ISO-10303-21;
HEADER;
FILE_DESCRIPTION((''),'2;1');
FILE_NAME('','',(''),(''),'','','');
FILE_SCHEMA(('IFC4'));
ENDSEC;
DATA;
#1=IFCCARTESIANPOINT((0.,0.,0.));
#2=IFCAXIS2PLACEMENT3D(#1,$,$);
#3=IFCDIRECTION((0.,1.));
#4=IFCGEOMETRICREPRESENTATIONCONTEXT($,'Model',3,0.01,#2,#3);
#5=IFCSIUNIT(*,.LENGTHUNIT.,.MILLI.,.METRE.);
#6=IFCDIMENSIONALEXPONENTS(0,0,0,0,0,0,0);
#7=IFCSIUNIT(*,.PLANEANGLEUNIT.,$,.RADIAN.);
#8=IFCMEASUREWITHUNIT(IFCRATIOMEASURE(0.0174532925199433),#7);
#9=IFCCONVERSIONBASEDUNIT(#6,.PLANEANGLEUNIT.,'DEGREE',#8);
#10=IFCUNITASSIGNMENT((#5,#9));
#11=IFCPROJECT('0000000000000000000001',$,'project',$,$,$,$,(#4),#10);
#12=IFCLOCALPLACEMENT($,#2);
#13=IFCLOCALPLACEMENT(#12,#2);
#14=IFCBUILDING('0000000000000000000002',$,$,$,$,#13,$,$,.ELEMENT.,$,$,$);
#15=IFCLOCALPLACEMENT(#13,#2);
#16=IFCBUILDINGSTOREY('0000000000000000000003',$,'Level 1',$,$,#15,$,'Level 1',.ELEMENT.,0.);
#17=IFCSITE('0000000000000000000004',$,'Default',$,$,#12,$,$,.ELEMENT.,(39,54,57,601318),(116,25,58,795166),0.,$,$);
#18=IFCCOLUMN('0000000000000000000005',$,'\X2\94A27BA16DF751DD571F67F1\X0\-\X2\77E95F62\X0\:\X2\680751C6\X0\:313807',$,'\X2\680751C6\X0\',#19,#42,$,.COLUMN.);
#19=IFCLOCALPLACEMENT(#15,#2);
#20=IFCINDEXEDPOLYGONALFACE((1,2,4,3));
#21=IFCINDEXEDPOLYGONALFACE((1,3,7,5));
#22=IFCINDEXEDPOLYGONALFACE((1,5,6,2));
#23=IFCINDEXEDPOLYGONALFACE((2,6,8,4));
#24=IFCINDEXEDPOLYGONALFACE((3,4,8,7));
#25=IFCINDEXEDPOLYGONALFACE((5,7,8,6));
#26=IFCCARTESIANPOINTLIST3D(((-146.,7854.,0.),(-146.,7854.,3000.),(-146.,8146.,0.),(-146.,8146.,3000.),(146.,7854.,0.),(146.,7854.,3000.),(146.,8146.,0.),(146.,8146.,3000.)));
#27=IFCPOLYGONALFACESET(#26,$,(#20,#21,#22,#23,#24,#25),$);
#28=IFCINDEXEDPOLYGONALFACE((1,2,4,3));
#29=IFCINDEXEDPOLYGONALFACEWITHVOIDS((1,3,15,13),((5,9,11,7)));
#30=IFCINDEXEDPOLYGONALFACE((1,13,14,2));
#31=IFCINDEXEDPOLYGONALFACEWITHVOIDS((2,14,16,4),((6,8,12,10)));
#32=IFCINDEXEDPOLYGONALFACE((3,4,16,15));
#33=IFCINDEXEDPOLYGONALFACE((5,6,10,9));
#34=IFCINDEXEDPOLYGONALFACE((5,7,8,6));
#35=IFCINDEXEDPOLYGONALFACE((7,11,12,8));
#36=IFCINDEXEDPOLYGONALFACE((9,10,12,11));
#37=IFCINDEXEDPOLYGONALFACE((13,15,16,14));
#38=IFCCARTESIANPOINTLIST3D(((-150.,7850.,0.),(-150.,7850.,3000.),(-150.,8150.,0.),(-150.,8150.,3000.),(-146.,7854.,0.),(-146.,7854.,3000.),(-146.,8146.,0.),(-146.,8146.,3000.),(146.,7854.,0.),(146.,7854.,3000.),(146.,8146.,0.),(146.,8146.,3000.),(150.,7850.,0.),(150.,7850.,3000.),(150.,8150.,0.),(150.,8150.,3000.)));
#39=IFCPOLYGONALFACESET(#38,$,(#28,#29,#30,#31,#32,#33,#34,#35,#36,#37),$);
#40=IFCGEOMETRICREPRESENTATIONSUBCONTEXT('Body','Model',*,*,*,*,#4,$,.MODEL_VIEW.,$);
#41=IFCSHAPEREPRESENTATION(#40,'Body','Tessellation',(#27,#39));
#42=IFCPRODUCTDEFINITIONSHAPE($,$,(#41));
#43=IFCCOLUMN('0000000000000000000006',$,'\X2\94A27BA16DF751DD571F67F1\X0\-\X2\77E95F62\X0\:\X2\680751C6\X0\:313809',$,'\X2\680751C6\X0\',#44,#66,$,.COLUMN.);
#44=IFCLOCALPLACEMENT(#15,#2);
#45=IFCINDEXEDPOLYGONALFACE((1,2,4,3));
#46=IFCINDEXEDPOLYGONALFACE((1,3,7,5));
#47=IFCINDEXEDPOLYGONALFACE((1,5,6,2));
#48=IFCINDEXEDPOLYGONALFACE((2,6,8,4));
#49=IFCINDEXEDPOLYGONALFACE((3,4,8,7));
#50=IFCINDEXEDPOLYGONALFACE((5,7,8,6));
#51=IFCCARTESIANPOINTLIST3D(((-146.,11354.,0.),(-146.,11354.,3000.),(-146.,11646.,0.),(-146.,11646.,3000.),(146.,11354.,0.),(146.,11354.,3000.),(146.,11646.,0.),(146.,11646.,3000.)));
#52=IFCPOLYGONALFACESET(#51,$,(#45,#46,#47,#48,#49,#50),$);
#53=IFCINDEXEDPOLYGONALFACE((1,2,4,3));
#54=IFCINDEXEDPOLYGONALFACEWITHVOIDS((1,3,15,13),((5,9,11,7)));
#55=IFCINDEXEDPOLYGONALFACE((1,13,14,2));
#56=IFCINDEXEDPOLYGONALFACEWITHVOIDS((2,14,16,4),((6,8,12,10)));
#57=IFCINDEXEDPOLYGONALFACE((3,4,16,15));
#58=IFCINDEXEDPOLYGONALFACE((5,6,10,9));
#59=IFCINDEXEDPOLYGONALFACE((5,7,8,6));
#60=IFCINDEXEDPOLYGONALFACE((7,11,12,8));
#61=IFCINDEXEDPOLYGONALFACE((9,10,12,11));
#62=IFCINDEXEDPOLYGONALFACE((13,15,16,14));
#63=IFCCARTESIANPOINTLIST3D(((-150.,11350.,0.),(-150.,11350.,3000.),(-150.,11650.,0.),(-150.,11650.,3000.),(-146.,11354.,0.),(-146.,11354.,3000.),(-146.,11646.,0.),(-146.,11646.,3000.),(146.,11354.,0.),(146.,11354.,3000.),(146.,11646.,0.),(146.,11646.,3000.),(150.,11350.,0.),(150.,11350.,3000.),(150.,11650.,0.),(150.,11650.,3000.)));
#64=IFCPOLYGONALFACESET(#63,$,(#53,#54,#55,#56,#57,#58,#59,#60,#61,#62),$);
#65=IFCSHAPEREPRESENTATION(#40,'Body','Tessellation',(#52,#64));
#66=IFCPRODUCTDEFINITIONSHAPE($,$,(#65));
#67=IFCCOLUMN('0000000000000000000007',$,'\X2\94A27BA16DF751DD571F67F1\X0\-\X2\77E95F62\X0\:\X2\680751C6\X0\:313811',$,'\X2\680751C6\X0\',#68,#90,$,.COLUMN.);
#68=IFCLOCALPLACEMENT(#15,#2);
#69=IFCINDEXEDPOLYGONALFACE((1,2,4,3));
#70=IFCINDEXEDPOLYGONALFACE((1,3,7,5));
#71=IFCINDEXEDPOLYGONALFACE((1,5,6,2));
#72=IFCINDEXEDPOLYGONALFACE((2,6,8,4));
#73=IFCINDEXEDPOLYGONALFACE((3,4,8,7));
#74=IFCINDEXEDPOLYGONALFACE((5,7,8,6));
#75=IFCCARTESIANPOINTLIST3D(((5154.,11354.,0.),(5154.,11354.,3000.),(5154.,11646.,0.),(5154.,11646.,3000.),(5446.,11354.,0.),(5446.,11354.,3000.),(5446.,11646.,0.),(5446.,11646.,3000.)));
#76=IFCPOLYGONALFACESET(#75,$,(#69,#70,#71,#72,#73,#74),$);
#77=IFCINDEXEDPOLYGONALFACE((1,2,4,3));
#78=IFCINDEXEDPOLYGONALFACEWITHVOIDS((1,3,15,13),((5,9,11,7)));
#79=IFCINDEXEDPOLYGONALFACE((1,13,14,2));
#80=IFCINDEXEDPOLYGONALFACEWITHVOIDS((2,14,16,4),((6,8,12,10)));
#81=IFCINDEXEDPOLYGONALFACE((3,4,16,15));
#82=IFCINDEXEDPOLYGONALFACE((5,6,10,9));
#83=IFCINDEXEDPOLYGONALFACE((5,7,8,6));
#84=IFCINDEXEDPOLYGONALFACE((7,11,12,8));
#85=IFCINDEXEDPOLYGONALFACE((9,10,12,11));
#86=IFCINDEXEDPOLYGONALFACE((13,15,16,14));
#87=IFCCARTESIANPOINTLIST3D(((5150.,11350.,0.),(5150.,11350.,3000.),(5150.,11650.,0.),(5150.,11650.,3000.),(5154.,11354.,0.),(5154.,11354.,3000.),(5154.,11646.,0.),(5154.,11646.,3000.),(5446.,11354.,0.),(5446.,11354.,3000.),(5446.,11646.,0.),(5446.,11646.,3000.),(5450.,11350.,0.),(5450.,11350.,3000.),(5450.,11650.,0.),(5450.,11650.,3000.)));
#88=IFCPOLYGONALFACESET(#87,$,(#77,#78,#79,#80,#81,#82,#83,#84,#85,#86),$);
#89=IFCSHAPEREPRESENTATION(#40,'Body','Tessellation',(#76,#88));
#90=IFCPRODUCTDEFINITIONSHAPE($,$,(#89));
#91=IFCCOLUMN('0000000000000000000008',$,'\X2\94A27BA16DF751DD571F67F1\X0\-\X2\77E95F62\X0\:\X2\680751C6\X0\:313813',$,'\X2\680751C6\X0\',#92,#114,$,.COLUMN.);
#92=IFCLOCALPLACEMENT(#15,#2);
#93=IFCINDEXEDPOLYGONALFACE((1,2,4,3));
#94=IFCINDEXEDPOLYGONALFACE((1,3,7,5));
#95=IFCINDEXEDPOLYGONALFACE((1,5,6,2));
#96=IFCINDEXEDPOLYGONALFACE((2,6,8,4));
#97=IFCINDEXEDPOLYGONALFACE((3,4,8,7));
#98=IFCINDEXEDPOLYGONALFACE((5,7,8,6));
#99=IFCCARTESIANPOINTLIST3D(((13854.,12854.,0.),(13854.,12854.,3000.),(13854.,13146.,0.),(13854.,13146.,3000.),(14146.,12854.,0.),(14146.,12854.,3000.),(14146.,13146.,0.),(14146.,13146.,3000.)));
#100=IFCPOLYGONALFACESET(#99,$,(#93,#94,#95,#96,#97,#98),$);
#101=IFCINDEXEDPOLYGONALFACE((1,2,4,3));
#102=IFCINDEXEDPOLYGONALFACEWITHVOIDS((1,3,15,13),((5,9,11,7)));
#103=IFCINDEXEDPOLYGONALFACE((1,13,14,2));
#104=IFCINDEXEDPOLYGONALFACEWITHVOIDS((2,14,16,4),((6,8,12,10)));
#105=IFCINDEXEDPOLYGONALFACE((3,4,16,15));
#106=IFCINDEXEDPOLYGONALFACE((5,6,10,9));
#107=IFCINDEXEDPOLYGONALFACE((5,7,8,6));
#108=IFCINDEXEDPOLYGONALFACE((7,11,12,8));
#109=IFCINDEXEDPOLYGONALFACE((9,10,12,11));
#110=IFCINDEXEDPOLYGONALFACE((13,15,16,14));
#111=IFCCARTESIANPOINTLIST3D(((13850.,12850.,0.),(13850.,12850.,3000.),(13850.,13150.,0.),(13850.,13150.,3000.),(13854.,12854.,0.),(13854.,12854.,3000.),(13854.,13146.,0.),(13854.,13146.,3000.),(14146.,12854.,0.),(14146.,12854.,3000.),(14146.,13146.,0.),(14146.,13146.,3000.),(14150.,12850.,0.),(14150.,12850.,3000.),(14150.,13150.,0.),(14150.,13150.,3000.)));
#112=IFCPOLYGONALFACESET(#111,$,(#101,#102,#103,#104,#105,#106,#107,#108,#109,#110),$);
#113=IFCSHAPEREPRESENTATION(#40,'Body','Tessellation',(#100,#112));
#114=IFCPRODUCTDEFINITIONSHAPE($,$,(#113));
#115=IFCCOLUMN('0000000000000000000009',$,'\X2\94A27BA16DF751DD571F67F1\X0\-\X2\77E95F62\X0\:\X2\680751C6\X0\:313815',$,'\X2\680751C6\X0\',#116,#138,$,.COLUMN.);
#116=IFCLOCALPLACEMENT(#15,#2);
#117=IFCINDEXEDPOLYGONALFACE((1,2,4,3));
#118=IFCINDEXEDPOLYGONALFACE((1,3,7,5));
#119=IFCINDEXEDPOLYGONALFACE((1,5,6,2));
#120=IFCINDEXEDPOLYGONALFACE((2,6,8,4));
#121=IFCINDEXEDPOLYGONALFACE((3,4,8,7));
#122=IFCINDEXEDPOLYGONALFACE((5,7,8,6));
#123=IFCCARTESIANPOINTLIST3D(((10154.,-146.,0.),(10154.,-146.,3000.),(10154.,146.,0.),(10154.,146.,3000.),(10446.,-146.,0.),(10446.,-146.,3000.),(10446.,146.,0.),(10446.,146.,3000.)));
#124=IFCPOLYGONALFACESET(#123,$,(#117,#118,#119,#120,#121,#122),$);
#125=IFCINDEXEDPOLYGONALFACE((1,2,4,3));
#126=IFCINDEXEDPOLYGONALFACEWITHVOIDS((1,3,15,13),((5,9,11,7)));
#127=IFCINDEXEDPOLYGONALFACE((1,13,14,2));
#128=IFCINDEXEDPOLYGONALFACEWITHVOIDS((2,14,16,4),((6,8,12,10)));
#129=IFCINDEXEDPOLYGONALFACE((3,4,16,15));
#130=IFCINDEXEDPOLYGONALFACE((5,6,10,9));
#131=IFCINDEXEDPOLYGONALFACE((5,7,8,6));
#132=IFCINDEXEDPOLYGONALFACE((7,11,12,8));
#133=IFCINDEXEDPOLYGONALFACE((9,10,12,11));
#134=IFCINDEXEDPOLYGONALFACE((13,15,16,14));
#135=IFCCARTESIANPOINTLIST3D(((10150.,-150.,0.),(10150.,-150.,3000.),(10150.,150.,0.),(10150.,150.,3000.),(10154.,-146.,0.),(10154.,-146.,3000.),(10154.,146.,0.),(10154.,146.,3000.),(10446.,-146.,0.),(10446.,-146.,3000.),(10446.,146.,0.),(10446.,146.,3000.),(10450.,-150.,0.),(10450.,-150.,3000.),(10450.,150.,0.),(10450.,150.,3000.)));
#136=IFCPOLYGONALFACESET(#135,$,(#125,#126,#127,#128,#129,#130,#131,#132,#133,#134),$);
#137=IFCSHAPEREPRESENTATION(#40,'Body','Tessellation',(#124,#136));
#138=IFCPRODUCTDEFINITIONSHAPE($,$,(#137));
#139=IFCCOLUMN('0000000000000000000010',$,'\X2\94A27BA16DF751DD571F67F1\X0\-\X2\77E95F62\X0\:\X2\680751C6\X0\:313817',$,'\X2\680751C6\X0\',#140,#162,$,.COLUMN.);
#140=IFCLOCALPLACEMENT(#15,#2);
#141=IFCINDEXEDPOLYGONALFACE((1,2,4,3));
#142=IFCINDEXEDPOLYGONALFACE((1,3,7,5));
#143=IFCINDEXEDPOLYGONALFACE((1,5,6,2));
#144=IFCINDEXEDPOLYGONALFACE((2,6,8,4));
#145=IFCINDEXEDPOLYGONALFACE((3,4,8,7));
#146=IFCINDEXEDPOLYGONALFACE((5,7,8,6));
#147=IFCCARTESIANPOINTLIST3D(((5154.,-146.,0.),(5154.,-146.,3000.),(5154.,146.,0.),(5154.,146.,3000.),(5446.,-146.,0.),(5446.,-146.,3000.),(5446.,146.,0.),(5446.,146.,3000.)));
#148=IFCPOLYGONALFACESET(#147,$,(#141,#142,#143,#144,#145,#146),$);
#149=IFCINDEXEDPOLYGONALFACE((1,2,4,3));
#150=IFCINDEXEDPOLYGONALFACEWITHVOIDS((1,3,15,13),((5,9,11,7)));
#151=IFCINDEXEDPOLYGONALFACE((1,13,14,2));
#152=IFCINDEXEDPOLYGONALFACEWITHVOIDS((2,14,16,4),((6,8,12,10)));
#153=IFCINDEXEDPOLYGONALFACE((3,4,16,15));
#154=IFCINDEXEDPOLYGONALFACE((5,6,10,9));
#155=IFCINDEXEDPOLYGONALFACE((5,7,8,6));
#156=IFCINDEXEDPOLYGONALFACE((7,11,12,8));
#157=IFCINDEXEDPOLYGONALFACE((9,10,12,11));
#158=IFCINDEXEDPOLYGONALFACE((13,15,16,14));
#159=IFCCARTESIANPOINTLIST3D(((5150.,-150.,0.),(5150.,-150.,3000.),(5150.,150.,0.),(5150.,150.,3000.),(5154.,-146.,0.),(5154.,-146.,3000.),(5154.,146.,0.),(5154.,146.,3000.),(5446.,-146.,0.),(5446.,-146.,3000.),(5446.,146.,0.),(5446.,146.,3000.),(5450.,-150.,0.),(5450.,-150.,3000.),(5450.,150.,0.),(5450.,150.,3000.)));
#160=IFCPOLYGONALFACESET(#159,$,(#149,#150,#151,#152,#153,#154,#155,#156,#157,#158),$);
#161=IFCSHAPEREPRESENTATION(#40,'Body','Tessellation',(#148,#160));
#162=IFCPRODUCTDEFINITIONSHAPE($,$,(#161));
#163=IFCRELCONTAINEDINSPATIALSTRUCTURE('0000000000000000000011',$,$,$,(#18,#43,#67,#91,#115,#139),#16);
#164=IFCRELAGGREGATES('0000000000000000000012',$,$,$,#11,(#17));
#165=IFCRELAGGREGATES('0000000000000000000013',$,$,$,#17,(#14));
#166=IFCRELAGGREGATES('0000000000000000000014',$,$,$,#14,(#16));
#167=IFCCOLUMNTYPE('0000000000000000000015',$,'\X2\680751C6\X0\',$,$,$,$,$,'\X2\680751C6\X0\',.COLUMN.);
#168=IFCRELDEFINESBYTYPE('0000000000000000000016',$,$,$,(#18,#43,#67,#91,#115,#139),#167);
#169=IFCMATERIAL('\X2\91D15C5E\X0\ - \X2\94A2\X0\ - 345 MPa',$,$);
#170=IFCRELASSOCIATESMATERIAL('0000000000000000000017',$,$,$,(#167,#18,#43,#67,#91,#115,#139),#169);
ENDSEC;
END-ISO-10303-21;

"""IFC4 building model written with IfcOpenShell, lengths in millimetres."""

from ifc_helpers import new_model, entity, si_unit, converted_unit, direction, frame, origin, origin_2d_with_axis, place, context, subcontext, project, spatial, polyline, rectangle, outline, extrude, source, transform, mapped, material, type_object, type_shapes, element, save


model = new_model("IFC4")

# Units and contexts
model_context = context("Model", 3, precision=0.01, world=origin(), true_north=direction((0.0, 1.0)))
body_context = subcontext(model_context, "Body", "Model", "MODEL_VIEW")
ifc_project = project(units=[si_unit("LENGTHUNIT", "METRE", prefix="MILLI"), converted_unit("PLANEANGLEUNIT", "DEGREE", entity("IfcRatioMeasure", 0.0174532925199433), si_unit("PLANEANGLEUNIT", "RADIAN"), dimensions=[0, 0, 0, 0, 0, 0, 0])], contexts=[model_context])

# Site, building, storey
site_placement = place(None, origin())
site = spatial("IfcSite", under=ifc_project, at=site_placement, Name="Default", CompositionType="ELEMENT", RefLatitude=(39, 54, 57, 601318), RefLongitude=(116, 25, 58, 795166), RefElevation=0.0)
building_placement = place(site_placement, origin())
building = spatial("IfcBuilding", under=site, at=building_placement, CompositionType="ELEMENT")
storey_placement = place(building_placement, origin())
storey = spatial("IfcBuildingStorey", under=building, at=storey_placement, Name="Level 1", LongName="Level 1", CompositionType="ELEMENT", Elevation=0.0)

# Columns
ifc_material = material(Name="金属 - 钢 - 345 MPa")
column_type = type_object("IfcColumnType", Name="标准", ElementType="标准", PredefinedType="COLUMN", material=ifc_material)
shared_shape = source(origin(), body_context, "Body", "SweptSolid", [
    extrude(rectangle(XDim=292.0, YDim=292.0, at=origin_2d_with_axis()), frame((0.0, 0.0, 0.0), z_axis=(0.0, 0.0, 1.0), x_axis=(-1.0, 0.0, 0.0)), (0.0, 0.0, 1.0), 3000.0),
    extrude(outline(polyline([(-150.0, -150.0), (150.0, -150.0), (150.0, 150.0), (-150.0, 150.0), (-150.0, -150.0)]), holes=[polyline([(-146.0, -146.0), (-146.0, 146.0), (146.0, 146.0), (146.0, -146.0), (-146.0, -146.0)])]), frame((0.0, 0.0, 0.0), z_axis=(0.0, 0.0, 1.0), x_axis=(-1.0, 0.0, 0.0)), (0.0, 0.0, 1.0), 3000.0),
])
type_shapes(column_type, [shared_shape])
for number, where, name in (
    (1, (0.0, 8000.0, 0.0), "钢管混凝土柱-矩形:标准:313807"),
    (2, (0.0, 11500.0, 0.0), "钢管混凝土柱-矩形:标准:313809"),
    (3, (5300.0, 11500.0, 0.0), "钢管混凝土柱-矩形:标准:313811"),
    (4, (14000.0, 13000.0, 0.0), "钢管混凝土柱-矩形:标准:313813"),
    (5, (10300.0, 0.0, 0.0), "钢管混凝土柱-矩形:标准:313815"),
    (6, (5300.0, 0.0, 0.0), "钢管混凝土柱-矩形:标准:313817"),
):
    element("IfcColumn", number, at=place(storey_placement, frame(where)), inside=storey, type_object=column_type, material=ifc_material, Name=name, ObjectType="标准", PredefinedType="COLUMN", context=body_context, shape_type="MappedRepresentation", body=[
        mapped(shared_shape, transform((0.0, 0.0, 0.0), scale=1.0)),
    ])

save(model, "model.ifc")
